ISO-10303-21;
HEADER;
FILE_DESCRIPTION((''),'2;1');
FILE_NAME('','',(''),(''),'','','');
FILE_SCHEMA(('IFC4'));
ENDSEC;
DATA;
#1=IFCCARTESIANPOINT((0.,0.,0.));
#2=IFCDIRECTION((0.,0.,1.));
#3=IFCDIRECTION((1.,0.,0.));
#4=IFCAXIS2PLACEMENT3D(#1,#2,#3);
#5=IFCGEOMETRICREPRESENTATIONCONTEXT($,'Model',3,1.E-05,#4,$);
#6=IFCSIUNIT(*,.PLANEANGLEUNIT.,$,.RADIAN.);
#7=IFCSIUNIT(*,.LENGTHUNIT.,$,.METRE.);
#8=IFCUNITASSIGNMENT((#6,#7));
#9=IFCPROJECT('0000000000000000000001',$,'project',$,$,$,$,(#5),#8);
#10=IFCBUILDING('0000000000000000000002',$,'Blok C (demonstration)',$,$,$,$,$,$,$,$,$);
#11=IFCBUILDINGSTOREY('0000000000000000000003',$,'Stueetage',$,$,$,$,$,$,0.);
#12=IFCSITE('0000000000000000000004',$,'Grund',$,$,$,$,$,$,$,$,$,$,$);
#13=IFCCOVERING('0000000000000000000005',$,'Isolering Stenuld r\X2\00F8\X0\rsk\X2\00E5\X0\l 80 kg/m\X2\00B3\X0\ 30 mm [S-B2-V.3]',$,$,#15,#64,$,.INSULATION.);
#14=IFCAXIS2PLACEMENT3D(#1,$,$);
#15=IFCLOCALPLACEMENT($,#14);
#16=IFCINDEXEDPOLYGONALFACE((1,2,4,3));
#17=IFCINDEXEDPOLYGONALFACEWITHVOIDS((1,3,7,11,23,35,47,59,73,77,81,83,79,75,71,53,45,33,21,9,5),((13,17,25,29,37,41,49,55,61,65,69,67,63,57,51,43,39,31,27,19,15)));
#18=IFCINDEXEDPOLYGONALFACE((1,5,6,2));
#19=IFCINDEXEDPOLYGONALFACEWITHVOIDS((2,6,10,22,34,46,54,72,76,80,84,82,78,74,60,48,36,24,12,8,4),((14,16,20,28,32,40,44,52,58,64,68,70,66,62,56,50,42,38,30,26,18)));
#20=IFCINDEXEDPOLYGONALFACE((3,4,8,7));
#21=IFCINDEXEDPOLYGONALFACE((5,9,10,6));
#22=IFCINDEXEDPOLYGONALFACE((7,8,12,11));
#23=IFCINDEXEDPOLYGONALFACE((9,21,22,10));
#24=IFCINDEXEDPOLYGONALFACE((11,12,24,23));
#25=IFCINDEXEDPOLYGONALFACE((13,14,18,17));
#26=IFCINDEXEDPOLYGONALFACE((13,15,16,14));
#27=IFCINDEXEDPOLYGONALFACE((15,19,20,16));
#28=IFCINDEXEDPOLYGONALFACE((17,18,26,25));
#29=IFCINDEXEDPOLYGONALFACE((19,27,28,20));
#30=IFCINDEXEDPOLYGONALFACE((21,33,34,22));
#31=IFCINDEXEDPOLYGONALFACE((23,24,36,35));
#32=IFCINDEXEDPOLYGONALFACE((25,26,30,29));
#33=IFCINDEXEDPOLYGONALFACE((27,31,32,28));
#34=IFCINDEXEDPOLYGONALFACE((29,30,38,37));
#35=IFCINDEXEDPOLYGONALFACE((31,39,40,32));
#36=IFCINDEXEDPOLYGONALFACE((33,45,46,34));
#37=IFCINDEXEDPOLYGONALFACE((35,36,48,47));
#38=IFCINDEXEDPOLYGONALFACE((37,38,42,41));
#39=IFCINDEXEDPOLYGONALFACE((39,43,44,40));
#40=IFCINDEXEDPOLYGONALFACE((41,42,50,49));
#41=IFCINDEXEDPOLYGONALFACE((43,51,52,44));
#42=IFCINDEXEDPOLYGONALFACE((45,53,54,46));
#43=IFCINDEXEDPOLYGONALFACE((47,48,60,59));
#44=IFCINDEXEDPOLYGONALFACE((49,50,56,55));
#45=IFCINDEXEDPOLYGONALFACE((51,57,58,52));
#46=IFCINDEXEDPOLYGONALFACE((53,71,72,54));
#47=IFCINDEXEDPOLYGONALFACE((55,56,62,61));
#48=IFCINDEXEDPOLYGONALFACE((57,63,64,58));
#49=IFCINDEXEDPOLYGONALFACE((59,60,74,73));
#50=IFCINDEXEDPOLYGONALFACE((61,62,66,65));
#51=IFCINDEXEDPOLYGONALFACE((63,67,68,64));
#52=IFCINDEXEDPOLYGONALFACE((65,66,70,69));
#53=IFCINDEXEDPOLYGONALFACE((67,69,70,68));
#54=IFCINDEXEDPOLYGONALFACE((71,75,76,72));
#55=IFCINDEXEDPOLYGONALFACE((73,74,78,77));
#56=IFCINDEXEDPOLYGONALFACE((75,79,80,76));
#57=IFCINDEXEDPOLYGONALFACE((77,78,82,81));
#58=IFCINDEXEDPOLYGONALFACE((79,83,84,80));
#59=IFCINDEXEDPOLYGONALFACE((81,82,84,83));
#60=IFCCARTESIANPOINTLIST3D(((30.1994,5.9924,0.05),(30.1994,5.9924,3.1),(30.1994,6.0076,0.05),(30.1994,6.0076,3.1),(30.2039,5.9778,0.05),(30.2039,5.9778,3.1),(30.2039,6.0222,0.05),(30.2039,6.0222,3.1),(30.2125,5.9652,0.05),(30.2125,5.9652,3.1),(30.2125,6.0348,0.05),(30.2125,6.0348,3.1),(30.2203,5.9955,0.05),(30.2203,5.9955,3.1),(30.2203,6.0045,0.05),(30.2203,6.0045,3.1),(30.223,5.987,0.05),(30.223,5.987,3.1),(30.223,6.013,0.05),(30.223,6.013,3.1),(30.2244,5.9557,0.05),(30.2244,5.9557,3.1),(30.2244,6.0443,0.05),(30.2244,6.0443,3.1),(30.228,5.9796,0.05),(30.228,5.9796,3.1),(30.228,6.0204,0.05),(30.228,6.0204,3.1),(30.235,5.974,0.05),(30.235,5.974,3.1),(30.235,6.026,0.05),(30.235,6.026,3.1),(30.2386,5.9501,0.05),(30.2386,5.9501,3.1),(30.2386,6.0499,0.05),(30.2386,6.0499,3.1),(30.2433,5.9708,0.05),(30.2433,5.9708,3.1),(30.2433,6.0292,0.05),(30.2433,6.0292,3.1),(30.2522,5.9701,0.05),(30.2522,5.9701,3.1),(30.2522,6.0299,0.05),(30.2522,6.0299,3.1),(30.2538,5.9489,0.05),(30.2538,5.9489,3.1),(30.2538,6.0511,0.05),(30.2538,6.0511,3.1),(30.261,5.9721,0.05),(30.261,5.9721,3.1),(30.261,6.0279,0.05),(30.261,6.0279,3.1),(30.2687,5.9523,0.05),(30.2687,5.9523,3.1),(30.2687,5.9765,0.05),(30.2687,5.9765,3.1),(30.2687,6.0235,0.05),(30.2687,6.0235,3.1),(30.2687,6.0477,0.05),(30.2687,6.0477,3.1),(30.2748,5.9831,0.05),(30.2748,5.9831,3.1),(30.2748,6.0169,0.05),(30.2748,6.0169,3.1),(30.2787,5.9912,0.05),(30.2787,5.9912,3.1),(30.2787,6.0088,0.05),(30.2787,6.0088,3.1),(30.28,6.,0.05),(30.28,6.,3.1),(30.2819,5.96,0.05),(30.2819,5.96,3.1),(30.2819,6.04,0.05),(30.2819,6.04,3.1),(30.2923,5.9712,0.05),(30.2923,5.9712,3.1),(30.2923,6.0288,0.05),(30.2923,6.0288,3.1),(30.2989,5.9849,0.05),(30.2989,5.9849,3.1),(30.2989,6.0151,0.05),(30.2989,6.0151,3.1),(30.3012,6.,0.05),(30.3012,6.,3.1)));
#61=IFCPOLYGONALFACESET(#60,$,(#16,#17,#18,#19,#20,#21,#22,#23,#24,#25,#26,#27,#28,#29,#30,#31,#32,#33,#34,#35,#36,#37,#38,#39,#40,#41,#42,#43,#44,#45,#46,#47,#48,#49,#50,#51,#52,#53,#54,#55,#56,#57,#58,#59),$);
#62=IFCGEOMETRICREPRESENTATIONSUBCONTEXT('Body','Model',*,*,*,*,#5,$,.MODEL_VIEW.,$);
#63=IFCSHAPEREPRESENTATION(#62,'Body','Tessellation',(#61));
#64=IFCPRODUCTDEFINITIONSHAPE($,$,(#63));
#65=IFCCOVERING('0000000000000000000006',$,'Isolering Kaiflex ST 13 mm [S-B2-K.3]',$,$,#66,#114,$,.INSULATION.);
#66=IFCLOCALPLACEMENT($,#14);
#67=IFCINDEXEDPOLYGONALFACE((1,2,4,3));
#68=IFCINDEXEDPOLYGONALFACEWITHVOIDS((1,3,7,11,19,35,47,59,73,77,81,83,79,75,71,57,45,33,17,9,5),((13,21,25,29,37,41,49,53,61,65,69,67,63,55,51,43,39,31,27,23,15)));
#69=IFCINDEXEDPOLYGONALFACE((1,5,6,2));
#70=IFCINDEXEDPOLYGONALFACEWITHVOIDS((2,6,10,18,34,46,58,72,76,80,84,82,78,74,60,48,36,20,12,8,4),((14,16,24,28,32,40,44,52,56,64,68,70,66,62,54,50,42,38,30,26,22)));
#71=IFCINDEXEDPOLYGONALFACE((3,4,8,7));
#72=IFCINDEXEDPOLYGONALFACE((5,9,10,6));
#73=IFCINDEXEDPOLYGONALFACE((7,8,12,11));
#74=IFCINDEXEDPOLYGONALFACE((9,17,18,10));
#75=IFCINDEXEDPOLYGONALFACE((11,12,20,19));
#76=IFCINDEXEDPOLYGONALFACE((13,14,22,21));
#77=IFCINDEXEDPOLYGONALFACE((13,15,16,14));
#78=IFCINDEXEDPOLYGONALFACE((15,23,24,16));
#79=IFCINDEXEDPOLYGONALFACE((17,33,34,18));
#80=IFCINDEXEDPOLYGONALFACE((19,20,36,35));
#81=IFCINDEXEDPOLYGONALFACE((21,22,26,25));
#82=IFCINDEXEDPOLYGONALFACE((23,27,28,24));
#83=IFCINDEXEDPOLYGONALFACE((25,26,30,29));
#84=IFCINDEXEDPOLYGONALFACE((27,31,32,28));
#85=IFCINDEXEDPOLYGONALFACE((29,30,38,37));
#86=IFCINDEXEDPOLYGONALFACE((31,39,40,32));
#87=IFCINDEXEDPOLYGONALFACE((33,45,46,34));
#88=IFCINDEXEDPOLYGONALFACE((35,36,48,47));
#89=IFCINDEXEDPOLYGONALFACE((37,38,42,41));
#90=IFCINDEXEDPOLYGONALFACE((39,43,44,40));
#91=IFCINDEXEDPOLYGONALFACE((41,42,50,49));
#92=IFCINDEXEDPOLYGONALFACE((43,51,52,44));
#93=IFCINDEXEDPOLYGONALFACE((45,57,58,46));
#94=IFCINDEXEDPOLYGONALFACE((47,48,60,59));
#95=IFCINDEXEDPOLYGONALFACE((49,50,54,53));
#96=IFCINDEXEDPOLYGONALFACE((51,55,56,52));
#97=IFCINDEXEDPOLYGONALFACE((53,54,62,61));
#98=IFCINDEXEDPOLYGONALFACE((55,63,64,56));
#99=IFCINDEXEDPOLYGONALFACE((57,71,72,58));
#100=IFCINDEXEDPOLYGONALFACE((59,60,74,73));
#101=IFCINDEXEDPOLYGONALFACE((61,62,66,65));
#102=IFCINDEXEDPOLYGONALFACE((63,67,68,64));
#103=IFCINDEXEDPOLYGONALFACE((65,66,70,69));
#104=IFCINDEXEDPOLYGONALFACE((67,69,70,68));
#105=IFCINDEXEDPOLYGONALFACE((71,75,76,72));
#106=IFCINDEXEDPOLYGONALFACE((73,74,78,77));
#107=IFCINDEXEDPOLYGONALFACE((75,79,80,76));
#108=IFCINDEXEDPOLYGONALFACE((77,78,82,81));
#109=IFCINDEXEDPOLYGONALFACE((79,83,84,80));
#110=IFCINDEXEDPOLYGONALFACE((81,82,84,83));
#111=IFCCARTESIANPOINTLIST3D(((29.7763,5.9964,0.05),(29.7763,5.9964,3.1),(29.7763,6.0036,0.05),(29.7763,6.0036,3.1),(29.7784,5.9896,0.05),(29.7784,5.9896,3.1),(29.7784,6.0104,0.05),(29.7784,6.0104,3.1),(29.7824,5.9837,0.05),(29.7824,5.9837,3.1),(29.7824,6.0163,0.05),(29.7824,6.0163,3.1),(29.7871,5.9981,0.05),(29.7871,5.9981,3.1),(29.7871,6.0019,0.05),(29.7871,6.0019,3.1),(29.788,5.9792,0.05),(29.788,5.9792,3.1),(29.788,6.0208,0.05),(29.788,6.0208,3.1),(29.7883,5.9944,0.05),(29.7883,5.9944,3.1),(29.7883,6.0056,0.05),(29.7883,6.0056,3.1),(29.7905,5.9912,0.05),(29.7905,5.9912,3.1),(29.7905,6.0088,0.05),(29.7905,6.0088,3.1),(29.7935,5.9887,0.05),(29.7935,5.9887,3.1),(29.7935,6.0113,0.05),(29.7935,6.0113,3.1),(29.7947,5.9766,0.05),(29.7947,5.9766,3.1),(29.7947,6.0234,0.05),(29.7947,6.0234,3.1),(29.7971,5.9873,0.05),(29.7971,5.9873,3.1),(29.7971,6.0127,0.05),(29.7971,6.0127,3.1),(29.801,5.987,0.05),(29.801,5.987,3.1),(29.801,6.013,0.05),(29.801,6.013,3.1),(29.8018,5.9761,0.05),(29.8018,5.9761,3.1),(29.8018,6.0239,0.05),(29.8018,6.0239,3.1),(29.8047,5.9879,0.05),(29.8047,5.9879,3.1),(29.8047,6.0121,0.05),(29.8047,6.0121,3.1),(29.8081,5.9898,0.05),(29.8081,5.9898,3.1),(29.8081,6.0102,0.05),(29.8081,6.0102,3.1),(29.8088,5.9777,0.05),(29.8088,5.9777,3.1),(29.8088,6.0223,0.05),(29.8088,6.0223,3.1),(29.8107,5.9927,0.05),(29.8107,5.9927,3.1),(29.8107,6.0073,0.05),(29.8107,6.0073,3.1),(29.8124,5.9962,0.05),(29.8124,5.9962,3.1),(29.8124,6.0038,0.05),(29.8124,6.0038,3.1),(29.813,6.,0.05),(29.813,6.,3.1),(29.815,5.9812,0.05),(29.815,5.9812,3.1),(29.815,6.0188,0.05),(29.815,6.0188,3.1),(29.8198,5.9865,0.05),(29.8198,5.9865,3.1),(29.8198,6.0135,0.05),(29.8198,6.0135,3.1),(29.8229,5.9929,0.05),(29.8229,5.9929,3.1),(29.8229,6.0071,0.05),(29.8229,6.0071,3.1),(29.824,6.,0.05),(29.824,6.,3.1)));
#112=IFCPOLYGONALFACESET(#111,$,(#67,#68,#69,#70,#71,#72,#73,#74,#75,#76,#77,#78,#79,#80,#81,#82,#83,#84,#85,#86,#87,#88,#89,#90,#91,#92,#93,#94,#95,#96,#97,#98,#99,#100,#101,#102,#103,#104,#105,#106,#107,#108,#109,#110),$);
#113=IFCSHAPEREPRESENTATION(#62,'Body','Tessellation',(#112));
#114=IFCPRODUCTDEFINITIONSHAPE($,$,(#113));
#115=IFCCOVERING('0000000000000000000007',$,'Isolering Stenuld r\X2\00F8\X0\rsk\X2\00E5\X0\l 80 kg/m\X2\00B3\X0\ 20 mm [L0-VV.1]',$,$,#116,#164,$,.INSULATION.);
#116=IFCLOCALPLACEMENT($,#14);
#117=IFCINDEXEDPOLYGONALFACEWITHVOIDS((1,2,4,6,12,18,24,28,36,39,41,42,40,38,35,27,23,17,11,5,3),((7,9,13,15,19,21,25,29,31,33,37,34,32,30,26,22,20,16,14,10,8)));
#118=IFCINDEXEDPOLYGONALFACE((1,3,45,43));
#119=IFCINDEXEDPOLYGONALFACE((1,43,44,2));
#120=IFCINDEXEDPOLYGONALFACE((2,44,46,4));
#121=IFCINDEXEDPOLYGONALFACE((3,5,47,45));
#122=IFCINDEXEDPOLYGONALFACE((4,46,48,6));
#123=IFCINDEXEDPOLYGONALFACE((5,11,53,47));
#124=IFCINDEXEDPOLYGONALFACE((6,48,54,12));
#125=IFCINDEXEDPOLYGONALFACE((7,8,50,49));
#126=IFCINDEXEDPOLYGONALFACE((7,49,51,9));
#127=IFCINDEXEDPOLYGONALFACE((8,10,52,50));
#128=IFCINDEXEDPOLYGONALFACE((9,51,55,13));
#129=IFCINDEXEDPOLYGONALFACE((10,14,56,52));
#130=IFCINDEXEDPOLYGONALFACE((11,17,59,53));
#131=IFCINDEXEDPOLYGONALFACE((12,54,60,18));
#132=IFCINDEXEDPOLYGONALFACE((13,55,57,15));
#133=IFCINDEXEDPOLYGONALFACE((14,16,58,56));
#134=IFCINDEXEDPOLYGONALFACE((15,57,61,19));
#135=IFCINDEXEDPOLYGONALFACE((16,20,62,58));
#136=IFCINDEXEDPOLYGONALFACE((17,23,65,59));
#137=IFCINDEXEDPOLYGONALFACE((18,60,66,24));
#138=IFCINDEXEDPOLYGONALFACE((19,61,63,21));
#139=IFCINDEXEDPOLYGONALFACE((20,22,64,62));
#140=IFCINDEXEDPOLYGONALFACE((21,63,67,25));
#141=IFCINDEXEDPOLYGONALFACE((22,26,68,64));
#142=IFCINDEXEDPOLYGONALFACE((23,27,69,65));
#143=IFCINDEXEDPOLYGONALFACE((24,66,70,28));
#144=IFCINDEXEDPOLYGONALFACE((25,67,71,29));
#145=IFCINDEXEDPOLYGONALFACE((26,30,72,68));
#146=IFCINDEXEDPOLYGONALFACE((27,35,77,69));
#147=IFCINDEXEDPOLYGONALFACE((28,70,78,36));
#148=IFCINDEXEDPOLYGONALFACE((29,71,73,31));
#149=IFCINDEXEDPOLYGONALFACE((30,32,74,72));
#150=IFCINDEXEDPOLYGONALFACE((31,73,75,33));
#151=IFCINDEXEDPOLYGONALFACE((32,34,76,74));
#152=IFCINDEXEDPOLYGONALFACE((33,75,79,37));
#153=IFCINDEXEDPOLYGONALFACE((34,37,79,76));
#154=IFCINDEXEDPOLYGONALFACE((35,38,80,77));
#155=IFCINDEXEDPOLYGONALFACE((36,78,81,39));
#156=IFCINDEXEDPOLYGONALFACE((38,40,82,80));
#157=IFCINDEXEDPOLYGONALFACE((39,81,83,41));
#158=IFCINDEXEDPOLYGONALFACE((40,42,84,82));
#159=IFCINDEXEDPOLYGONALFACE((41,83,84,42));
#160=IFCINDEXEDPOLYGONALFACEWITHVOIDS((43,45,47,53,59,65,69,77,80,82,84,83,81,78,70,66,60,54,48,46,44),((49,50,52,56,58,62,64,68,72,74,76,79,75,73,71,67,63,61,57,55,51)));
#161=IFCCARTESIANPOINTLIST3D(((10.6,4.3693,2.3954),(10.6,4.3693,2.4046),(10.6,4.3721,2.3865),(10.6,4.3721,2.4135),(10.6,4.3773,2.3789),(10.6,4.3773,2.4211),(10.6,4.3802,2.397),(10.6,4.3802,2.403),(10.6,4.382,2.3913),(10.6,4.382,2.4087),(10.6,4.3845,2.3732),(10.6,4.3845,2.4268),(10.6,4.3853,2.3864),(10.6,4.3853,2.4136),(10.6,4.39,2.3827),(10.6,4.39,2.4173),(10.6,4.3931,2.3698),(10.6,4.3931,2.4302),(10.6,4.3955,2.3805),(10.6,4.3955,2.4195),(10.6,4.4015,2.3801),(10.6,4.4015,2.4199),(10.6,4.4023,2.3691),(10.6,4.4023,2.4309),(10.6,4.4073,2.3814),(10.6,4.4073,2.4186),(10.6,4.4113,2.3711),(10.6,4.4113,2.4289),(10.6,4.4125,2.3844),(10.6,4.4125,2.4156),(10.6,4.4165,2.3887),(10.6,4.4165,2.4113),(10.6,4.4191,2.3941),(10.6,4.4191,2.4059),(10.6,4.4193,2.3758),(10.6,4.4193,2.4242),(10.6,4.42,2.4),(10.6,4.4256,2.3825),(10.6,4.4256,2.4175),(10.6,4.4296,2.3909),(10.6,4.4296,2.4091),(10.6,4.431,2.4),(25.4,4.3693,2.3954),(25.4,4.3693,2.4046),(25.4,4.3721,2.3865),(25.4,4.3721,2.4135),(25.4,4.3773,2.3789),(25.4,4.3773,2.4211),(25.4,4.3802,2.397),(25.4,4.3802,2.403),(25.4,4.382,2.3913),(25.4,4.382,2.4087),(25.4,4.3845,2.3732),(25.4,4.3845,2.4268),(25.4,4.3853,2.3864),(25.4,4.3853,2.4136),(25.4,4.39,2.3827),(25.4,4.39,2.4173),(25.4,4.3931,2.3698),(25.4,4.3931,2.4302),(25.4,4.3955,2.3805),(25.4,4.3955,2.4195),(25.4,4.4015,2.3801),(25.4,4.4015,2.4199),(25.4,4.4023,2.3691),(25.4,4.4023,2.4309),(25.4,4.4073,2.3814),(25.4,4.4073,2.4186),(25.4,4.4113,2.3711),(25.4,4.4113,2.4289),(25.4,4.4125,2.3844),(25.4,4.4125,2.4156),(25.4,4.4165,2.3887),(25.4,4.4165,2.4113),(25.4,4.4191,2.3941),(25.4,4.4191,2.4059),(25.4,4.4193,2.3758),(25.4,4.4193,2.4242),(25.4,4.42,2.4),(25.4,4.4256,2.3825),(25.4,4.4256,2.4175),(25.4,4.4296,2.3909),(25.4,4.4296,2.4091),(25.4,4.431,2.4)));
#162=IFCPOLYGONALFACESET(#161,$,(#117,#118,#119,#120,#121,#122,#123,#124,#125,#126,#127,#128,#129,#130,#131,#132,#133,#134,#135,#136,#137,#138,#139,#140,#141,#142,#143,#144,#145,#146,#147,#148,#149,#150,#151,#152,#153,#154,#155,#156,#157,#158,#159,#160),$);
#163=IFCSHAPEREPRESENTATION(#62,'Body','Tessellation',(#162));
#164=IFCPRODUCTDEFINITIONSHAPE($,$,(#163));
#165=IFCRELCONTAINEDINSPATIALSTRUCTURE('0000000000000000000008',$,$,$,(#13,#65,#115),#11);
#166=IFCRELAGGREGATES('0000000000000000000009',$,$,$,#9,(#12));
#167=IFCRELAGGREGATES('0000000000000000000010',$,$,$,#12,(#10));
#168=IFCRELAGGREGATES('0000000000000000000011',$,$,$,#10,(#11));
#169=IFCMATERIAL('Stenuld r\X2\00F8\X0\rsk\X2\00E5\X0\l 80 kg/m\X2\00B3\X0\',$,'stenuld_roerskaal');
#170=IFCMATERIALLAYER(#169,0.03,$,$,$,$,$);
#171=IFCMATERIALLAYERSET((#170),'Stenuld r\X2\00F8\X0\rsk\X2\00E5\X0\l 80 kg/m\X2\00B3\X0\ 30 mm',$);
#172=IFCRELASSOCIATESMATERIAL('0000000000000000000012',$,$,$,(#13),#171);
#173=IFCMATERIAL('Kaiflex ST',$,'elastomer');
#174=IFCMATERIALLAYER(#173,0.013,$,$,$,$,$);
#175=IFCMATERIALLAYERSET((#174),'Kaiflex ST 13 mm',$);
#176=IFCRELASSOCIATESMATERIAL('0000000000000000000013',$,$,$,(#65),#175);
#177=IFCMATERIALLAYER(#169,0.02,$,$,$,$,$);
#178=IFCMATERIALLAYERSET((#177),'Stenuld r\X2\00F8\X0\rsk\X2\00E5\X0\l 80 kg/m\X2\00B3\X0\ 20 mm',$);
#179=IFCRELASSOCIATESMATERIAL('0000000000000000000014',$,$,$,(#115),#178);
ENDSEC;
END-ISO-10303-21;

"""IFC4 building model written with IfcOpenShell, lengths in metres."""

from ifc_helpers import new_model, si_unit, frame, origin_with_axes, place, context, subcontext, project, spatial, hollow_circle, extrude, material, layer, layer_set, element, save


model = new_model("IFC4")

# Units and contexts
model_context = context("Model", 3, precision=1e-05, world=origin_with_axes())
body_context = subcontext(model_context, "Body", "Model", "MODEL_VIEW")
ifc_project = project(units=[si_unit("PLANEANGLEUNIT", "RADIAN"), si_unit("LENGTHUNIT", "METRE")], contexts=[model_context])

# Site, building, storey
site = spatial("IfcSite", under=ifc_project, Name="Grund")
building = spatial("IfcBuilding", under=site, Name="Blok C (demonstration)")
storey = spatial("IfcBuildingStorey", under=building, Name="Stueetage", Elevation=0.0)

# Coverings
ifc_material_1 = material(Name="Stenuld rørskål 80 kg/m³", Category="stenuld_roerskaal")
ifc_material_2 = material(Name="Kaiflex ST", Category="elastomer")
ifc_layer_1 = layer(ifc_material_1, 0.03)
ifc_layer_set_1 = layer_set([ifc_layer_1], Name="Stenuld rørskål 80 kg/m³ 30 mm")
covering_1_placement = place(None, origin_with_axes())
element("IfcCovering", 1, at=covering_1_placement, inside=storey, material=ifc_layer_set_1, Name="Isolering Stenuld rørskål 80 kg/m³ 30 mm [S-B2-V.3]", PredefinedType="INSULATION", context=body_context, shape_type="SweptSolid", body=[
    extrude(hollow_circle(Radius=0.0512, WallThickness=0.0212), frame((30.25, 6.0, 0.05), z_axis=(0.0, 0.0, 1.0), x_axis=(1.0, 0.0, 0.0)), (0.0, 0.0, 1.0), 3.05),
])
ifc_layer_2 = layer(ifc_material_2, 0.013)
ifc_layer_set_2 = layer_set([ifc_layer_2], Name="Kaiflex ST 13 mm")
covering_2_placement = place(None, origin_with_axes())
element("IfcCovering", 2, at=covering_2_placement, inside=storey, material=ifc_layer_set_2, Name="Isolering Kaiflex ST 13 mm [S-B2-K.3]", PredefinedType="INSULATION", context=body_context, shape_type="SweptSolid", body=[
    extrude(hollow_circle(Radius=0.024, WallThickness=0.011), frame((29.8, 6.0, 0.05), z_axis=(0.0, 0.0, 1.0), x_axis=(1.0, 0.0, 0.0)), (0.0, 0.0, 1.0), 3.05),
])
ifc_layer_3 = layer(ifc_material_1, 0.02)
ifc_layer_set_3 = layer_set([ifc_layer_3], Name="Stenuld rørskål 80 kg/m³ 20 mm")
covering_3_placement = place(None, origin_with_axes())
element("IfcCovering", 3, at=covering_3_placement, inside=storey, material=ifc_layer_set_3, Name="Isolering Stenuld rørskål 80 kg/m³ 20 mm [L0-VV.1]", PredefinedType="INSULATION", context=body_context, shape_type="SweptSolid", body=[
    extrude(hollow_circle(Radius=0.031, WallThickness=0.011), frame((10.6, 4.4, 2.4), z_axis=(1.0, 0.0, 0.0), x_axis=(0.0, 1.0, 0.0)), (0.0, 0.0, 1.0), 14.8),
])

save(model, "model.ifc")
